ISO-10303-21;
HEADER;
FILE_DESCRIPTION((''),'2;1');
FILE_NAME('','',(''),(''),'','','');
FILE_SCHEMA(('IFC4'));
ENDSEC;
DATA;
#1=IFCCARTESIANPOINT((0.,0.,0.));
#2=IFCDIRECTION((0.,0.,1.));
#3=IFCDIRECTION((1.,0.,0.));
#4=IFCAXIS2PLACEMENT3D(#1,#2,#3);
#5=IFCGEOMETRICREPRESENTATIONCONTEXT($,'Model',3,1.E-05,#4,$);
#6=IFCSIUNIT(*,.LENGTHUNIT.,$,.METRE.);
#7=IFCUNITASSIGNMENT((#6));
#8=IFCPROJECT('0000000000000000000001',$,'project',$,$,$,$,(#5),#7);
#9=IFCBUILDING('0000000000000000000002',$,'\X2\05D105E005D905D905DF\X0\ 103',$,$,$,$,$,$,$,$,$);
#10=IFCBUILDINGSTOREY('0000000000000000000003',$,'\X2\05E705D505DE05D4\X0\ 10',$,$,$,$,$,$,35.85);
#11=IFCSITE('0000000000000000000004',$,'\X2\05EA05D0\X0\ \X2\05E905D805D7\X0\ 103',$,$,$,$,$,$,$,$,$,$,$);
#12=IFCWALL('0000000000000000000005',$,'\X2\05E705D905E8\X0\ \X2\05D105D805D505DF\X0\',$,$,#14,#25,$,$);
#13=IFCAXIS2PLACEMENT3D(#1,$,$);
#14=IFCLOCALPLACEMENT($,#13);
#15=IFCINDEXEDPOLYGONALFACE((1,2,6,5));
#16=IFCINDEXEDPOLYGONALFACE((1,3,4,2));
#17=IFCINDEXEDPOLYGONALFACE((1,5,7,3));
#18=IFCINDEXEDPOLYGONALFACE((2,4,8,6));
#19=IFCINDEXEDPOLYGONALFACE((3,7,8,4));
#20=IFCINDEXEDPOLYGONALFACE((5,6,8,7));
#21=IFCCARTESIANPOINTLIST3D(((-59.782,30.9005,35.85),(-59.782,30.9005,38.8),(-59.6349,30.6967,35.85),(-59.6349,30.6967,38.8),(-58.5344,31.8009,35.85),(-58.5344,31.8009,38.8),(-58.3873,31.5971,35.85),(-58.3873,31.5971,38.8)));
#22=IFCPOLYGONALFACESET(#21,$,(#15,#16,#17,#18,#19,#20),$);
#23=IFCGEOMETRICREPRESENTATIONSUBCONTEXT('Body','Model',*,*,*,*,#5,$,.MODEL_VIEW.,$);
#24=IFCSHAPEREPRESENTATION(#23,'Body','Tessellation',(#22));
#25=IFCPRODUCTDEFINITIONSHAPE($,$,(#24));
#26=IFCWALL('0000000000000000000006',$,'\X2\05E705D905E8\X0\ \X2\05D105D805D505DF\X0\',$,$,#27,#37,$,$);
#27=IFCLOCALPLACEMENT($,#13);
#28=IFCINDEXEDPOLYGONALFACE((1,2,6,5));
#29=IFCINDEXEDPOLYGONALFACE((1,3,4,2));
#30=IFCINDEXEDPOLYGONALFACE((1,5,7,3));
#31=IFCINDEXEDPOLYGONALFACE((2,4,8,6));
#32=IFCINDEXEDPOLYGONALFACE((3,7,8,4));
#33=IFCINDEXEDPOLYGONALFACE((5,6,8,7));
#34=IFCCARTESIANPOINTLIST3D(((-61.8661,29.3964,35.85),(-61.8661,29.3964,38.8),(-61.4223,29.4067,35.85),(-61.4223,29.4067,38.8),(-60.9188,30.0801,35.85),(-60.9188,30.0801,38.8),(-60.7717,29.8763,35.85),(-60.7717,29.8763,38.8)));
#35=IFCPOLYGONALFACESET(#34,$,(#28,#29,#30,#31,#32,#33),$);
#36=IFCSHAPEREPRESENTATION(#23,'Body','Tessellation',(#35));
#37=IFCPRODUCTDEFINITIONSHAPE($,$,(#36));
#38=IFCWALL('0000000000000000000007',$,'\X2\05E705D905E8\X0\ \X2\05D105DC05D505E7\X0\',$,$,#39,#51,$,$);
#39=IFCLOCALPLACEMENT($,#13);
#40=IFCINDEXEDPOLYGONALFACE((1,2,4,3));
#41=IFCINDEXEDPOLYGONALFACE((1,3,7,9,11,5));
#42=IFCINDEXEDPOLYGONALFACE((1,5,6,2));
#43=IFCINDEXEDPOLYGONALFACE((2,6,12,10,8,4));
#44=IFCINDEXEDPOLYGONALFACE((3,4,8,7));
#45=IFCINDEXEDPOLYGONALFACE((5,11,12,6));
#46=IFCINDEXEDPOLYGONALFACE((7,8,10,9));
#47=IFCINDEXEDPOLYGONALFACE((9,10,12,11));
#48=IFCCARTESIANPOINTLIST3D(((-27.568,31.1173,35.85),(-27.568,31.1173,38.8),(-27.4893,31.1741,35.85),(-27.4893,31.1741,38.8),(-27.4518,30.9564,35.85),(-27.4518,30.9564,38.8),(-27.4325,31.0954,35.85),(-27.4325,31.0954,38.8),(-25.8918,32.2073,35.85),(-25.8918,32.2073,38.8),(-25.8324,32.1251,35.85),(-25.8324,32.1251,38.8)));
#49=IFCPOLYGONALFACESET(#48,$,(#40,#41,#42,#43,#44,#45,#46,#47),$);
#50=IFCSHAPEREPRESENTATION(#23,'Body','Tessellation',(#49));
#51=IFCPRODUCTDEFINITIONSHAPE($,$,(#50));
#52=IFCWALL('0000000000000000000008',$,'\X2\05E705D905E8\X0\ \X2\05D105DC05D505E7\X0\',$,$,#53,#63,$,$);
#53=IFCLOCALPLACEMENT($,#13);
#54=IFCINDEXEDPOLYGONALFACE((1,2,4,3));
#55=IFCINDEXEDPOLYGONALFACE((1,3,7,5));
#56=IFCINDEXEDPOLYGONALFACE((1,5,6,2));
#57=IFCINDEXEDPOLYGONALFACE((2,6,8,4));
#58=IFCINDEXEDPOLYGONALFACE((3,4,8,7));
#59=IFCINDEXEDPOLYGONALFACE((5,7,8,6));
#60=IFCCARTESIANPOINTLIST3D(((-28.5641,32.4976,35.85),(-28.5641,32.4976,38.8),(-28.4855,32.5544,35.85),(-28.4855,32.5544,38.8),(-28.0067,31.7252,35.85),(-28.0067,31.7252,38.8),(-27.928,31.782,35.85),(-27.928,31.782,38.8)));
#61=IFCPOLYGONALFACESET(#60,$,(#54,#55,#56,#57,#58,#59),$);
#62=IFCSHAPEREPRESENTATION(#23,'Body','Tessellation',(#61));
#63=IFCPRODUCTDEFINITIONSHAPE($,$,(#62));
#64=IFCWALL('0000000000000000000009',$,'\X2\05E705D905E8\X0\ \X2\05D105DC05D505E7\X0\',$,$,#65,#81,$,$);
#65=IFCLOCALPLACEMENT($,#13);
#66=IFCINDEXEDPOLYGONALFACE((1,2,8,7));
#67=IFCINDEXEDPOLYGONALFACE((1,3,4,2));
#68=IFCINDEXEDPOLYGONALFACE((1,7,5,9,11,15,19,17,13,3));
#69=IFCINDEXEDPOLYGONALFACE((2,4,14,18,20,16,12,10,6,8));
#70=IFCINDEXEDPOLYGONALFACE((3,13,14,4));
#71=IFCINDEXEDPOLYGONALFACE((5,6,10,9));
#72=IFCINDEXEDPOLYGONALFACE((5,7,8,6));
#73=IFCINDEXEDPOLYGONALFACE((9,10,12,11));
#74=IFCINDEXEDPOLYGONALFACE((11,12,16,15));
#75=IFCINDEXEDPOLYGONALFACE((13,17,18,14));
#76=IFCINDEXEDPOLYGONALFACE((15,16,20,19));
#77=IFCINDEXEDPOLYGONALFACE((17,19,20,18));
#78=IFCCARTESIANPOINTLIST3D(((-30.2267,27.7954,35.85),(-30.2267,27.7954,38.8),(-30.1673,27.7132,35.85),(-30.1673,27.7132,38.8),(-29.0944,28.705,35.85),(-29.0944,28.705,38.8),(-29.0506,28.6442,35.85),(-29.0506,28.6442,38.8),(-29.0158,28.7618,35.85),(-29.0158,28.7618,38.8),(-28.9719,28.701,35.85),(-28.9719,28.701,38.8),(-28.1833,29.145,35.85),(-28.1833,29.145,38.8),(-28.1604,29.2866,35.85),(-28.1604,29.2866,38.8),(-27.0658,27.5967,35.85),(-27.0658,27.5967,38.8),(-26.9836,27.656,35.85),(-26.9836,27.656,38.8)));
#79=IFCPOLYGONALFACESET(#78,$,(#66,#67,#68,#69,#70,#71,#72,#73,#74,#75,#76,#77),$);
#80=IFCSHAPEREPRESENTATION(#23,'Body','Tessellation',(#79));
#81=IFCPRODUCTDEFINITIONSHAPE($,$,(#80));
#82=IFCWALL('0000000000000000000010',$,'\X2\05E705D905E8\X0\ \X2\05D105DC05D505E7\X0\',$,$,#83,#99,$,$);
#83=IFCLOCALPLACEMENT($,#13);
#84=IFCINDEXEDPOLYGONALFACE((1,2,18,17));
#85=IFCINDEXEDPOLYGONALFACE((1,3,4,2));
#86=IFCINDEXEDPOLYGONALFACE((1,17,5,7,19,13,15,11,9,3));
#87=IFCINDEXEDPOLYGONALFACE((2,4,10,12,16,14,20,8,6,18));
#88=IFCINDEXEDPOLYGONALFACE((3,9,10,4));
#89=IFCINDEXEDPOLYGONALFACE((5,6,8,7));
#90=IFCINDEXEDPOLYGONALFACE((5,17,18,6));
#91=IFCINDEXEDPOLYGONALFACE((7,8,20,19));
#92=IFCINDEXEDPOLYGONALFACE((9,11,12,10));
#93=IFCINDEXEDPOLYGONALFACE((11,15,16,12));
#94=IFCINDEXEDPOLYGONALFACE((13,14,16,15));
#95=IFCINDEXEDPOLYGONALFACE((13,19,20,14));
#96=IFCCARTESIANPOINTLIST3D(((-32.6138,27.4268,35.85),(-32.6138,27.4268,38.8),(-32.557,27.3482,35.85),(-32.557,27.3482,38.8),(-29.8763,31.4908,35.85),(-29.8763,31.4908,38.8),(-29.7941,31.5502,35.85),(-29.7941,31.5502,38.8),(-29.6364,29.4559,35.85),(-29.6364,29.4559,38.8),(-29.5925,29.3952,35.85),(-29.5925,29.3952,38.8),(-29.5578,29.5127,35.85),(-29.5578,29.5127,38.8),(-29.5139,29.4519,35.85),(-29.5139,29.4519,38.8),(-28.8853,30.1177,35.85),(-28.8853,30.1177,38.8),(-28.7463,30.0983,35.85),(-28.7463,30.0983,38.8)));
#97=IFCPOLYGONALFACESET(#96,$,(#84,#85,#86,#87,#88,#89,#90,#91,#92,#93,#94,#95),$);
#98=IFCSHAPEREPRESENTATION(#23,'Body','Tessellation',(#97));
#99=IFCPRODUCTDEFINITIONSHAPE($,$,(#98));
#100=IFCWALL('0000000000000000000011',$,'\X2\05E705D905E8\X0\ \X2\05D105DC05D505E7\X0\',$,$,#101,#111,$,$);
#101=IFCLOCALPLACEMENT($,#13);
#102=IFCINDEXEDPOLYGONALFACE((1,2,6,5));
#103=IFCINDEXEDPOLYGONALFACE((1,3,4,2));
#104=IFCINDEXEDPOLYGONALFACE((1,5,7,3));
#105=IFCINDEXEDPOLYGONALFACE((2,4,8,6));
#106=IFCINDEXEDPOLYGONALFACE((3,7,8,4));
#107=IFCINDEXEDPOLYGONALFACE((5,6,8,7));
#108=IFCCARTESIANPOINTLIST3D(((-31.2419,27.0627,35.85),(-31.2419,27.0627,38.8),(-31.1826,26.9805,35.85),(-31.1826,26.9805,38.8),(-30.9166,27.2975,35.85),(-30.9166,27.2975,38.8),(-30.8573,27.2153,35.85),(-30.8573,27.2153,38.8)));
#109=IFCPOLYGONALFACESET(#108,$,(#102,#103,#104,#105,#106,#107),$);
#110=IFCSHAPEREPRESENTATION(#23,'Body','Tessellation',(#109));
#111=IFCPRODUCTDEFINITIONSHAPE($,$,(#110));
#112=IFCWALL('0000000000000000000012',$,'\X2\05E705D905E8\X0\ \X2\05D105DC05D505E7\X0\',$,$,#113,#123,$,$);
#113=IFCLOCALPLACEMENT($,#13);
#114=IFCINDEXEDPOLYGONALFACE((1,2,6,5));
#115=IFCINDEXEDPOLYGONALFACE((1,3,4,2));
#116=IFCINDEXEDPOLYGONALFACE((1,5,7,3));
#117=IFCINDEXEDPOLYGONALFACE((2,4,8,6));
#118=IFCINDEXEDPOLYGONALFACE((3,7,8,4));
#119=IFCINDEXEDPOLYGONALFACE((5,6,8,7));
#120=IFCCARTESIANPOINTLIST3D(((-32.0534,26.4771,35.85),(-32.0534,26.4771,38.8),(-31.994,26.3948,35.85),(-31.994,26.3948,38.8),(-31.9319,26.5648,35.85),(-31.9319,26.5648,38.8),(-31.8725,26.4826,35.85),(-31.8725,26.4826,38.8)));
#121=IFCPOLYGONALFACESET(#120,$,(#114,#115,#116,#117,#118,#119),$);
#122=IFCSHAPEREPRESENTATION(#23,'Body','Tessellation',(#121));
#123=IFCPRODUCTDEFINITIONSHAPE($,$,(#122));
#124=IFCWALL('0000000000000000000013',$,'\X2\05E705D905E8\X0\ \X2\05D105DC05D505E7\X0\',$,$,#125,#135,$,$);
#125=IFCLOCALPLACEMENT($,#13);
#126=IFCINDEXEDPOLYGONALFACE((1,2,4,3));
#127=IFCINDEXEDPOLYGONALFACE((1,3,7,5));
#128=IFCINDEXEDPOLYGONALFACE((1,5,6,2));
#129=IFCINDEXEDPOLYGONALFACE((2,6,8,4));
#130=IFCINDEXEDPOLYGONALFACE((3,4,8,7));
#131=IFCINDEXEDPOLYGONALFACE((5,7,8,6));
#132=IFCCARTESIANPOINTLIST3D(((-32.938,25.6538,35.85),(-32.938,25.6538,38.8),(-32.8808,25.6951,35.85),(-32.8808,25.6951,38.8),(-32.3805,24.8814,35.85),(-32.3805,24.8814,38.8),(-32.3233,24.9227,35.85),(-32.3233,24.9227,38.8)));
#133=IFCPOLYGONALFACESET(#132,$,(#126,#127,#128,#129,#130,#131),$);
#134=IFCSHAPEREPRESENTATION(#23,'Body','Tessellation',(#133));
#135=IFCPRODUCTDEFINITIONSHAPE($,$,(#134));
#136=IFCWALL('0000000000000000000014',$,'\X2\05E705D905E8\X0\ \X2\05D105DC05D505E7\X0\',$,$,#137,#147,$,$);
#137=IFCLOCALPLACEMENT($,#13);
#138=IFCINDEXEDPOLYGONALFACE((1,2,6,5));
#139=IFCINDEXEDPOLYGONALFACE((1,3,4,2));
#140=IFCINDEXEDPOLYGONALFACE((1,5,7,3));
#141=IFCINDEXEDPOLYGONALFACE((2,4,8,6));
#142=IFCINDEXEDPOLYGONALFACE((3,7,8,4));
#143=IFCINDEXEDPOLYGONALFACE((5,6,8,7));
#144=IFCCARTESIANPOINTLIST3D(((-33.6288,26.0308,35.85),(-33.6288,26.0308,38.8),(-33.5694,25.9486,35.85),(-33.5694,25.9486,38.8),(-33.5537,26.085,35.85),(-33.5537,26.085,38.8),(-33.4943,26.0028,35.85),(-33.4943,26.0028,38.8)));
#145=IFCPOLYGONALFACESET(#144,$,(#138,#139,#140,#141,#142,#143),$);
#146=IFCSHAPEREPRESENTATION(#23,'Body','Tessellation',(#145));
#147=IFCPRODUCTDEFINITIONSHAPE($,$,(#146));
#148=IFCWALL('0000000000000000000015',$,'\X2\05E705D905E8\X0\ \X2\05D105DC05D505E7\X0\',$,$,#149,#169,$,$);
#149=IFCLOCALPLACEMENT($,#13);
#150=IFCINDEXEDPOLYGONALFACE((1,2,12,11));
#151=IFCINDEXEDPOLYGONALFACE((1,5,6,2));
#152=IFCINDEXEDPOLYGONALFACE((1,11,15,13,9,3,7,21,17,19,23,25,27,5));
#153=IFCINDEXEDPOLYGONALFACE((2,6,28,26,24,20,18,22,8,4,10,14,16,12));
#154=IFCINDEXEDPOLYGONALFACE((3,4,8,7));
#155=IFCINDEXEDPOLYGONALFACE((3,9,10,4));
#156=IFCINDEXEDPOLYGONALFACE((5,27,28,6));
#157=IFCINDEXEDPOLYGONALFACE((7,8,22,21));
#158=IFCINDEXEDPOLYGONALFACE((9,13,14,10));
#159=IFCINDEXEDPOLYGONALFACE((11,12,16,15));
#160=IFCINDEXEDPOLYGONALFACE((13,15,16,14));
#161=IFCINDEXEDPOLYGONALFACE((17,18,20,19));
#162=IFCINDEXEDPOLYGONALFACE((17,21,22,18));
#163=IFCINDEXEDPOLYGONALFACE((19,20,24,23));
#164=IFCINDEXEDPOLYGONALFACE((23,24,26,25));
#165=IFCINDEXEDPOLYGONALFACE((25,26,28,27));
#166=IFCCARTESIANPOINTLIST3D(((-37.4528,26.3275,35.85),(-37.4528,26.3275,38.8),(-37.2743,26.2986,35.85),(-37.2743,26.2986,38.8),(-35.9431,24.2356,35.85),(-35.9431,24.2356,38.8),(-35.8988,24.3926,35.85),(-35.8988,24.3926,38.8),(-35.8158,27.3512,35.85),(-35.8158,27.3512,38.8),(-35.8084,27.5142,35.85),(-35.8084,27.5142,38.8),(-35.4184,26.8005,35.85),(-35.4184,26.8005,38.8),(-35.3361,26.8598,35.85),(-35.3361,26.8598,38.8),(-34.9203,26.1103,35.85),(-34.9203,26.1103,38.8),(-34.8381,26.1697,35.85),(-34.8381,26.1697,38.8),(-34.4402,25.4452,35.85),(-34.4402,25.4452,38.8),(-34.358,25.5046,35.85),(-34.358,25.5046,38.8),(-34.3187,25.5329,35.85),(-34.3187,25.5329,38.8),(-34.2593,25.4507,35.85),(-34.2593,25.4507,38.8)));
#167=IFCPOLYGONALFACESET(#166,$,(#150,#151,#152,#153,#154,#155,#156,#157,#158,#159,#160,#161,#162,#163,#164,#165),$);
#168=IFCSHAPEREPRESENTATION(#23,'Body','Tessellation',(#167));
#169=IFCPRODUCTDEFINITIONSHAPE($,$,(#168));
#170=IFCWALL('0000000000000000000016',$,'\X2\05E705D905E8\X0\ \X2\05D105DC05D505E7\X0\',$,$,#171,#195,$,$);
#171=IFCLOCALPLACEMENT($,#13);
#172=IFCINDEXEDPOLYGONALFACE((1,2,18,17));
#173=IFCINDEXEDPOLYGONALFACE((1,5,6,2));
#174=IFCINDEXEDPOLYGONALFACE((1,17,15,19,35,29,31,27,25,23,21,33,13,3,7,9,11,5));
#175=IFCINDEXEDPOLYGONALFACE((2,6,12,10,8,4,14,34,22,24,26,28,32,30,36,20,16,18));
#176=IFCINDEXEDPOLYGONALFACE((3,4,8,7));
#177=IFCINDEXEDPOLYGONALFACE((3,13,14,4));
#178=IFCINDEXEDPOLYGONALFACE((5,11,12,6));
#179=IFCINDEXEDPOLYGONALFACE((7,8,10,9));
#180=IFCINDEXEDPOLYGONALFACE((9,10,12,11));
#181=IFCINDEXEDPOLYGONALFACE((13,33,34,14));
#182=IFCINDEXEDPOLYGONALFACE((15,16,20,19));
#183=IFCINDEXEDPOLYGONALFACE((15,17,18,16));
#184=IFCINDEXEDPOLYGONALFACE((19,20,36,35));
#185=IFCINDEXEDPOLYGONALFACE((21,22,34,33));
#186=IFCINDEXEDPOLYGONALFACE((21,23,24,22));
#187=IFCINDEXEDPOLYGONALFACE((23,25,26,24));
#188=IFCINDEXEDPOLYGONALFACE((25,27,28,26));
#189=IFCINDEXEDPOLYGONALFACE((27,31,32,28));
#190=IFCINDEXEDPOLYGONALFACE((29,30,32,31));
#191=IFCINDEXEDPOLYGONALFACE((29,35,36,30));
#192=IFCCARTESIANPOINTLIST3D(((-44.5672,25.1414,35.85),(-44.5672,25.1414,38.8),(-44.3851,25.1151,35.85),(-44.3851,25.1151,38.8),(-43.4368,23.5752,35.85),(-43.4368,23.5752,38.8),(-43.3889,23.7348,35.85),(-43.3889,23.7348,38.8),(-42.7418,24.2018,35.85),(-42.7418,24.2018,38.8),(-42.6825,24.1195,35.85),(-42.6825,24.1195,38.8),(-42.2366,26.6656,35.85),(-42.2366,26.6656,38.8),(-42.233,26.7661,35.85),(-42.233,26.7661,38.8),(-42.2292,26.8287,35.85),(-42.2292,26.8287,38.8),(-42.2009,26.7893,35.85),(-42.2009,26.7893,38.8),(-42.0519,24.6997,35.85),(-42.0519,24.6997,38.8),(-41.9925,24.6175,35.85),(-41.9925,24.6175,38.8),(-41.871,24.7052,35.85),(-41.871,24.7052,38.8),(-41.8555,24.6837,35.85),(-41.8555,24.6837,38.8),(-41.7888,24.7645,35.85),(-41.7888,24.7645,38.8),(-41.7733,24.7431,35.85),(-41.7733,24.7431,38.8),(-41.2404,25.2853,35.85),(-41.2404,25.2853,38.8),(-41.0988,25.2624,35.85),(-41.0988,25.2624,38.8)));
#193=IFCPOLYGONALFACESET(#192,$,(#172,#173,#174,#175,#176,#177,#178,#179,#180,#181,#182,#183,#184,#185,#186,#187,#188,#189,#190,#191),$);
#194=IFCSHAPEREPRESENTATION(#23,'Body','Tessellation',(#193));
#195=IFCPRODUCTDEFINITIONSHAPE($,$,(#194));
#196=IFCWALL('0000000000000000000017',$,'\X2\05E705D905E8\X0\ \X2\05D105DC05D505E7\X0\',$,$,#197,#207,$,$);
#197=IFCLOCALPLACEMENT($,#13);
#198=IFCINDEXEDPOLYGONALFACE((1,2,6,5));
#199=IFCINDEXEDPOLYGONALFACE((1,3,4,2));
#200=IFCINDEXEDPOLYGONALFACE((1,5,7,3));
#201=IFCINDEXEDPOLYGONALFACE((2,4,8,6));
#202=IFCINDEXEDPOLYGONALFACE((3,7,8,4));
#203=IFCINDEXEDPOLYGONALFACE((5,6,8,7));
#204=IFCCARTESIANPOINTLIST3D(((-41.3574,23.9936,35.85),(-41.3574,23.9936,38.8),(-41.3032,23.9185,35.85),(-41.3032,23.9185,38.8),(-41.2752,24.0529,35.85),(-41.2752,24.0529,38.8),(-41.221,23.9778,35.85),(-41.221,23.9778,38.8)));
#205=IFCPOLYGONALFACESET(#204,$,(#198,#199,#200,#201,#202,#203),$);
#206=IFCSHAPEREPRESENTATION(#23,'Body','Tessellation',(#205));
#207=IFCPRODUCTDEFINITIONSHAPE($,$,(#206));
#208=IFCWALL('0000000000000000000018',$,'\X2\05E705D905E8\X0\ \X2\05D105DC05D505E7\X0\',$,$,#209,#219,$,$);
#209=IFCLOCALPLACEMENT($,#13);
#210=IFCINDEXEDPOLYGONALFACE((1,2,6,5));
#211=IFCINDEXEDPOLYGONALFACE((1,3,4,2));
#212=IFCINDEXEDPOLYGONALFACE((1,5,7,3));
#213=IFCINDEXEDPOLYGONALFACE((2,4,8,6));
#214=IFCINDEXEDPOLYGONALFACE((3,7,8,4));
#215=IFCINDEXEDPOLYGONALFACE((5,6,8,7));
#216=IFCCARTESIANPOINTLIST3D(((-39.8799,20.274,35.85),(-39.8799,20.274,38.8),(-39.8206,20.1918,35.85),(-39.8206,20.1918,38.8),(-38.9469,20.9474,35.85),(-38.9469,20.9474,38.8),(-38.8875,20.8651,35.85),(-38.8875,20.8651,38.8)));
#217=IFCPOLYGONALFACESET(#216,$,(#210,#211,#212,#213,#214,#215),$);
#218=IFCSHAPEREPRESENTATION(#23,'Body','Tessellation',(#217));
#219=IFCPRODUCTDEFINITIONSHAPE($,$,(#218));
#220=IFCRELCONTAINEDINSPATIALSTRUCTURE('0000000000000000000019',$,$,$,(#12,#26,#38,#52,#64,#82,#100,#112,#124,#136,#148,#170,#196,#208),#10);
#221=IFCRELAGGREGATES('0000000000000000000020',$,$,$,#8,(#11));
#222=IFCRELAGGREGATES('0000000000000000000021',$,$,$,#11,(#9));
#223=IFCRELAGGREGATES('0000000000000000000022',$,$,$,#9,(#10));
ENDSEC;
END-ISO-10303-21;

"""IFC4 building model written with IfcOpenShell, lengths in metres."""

from ifc_helpers import new_model, si_unit, frame, origin_with_axes, context, subcontext, project, spatial, polyline, outline, extrude, element, save


model = new_model("IFC4")

# Units and contexts
model_context = context("Model", 3, precision=1e-05, world=origin_with_axes())
body_context = subcontext(model_context, "Body", "Model", "MODEL_VIEW")
ifc_project = project(units=[si_unit("LENGTHUNIT", "METRE")], contexts=[model_context])

# Site, building, storey
site = spatial("IfcSite", under=ifc_project, Name="תא שטח 103")
building = spatial("IfcBuilding", under=site, Name="בניין 103")
storey = spatial("IfcBuildingStorey", under=building, Name="קומה 10", Elevation=35.85)

# Walls
element("IfcWall", 1, inside=storey, Name="קיר בטון", context=body_context, shape_type="SweptSolid", body=[
    extrude(outline(polyline([(-59.6349, 30.6967), (-59.782, 30.9005), (-58.5344, 31.8009), (-58.3873, 31.5971), (-59.6349, 30.6967)])), frame((0.0, 0.0, 35.85)), (0.0, 0.0, 1.0), 2.95),
])
element("IfcWall", 2, inside=storey, Name="קיר בטון", context=body_context, shape_type="SweptSolid", body=[
    extrude(outline(polyline([(-61.4223, 29.4067), (-61.8661, 29.3964), (-60.9188, 30.0801), (-60.7717, 29.8763), (-61.4223, 29.4067)])), frame((0.0, 0.0, 35.85)), (0.0, 0.0, 1.0), 2.95),
])
element("IfcWall", 3, inside=storey, Name="קיר בלוק", context=body_context, shape_type="SweptSolid", body=[
    extrude(outline(polyline([(-27.4893, 31.1741), (-27.4325, 31.0954), (-25.8918, 32.2073), (-25.8324, 32.1251), (-27.4518, 30.9564), (-27.568, 31.1173), (-27.4893, 31.1741)])), frame((0.0, 0.0, 35.85)), (0.0, 0.0, 1.0), 2.95),
])
element("IfcWall", 4, inside=storey, Name="קיר בלוק", context=body_context, shape_type="SweptSolid", body=[
    extrude(outline(polyline([(-28.4855, 32.5544), (-27.928, 31.782), (-28.0067, 31.7252), (-28.5641, 32.4976), (-28.4855, 32.5544)])), frame((0.0, 0.0, 35.85)), (0.0, 0.0, 1.0), 2.95),
])
element("IfcWall", 5, inside=storey, Name="קיר בלוק", context=body_context, shape_type="SweptSolid", body=[
    extrude(outline(polyline([(-30.1673, 27.7132), (-30.2267, 27.7954), (-29.0506, 28.6442), (-29.0944, 28.705), (-29.0158, 28.7618), (-28.9719, 28.701), (-28.1604, 29.2866), (-26.9836, 27.656), (-27.0658, 27.5967), (-28.1833, 29.145), (-30.1673, 27.7132)])), frame((0.0, 0.0, 35.85)), (0.0, 0.0, 1.0), 2.95),
])
element("IfcWall", 6, inside=storey, Name="קיר בלוק", context=body_context, shape_type="SweptSolid", body=[
    extrude(outline(polyline([(-29.5925, 29.3952), (-29.6364, 29.4559), (-32.557, 27.3482), (-32.6138, 27.4268), (-28.8853, 30.1177), (-29.8763, 31.4908), (-29.7941, 31.5502), (-28.7463, 30.0983), (-29.5578, 29.5127), (-29.5139, 29.4519), (-29.5925, 29.3952)])), frame((0.0, 0.0, 35.85)), (0.0, 0.0, 1.0), 2.95),
])
element("IfcWall", 7, inside=storey, Name="קיר בלוק", context=body_context, shape_type="SweptSolid", body=[
    extrude(outline(polyline([(-30.9166, 27.2975), (-30.8573, 27.2153), (-31.1826, 26.9805), (-31.2419, 27.0627), (-30.9166, 27.2975)])), frame((0.0, 0.0, 35.85)), (0.0, 0.0, 1.0), 2.95),
])
element("IfcWall", 8, inside=storey, Name="קיר בלוק", context=body_context, shape_type="SweptSolid", body=[
    extrude(outline(polyline([(-31.8725, 26.4826), (-31.994, 26.3948), (-32.0534, 26.4771), (-31.9319, 26.5648), (-31.8725, 26.4826)])), frame((0.0, 0.0, 35.85)), (0.0, 0.0, 1.0), 2.95),
])
element("IfcWall", 9, inside=storey, Name="קיר בלוק", context=body_context, shape_type="SweptSolid", body=[
    extrude(outline(polyline([(-32.3233, 24.9227), (-32.3805, 24.8814), (-32.938, 25.6538), (-32.8808, 25.6951), (-32.3233, 24.9227)])), frame((0.0, 0.0, 35.85)), (0.0, 0.0, 1.0), 2.95),
])
element("IfcWall", 10, inside=storey, Name="קיר בלוק", context=body_context, shape_type="SweptSolid", body=[
    extrude(outline(polyline([(-33.5537, 26.085), (-33.4943, 26.0028), (-33.5694, 25.9486), (-33.6288, 26.0308), (-33.5537, 26.085)])), frame((0.0, 0.0, 35.85)), (0.0, 0.0, 1.0), 2.95),
])
element("IfcWall", 11, inside=storey, Name="קיר בלוק", context=body_context, shape_type="SweptSolid", body=[
    extrude(outline(polyline([(-35.8988, 24.3926), (-34.4402, 25.4452), (-34.9203, 26.1103), (-34.8381, 26.1697), (-34.358, 25.5046), (-34.3187, 25.5329), (-34.2593, 25.4507), (-35.9431, 24.2356), (-37.4528, 26.3275), (-35.8084, 27.5142), (-35.3361, 26.8598), (-35.4184, 26.8005), (-35.8158, 27.3512), (-37.2743, 26.2986), (-35.8988, 24.3926)])), frame((0.0, 0.0, 35.85)), (0.0, 0.0, 1.0), 2.95),
])
element("IfcWall", 12, inside=storey, Name="קיר בלוק", context=body_context, shape_type="SweptSolid", body=[
    extrude(outline(polyline([(-41.8555, 24.6837), (-41.871, 24.7052), (-41.9925, 24.6175), (-42.0519, 24.6997), (-41.2404, 25.2853), (-42.2366, 26.6656), (-44.3851, 25.1151), (-43.3889, 23.7348), (-42.7418, 24.2018), (-42.6825, 24.1195), (-43.4368, 23.5752), (-44.5672, 25.1414), (-42.2292, 26.8287), (-42.233, 26.7661), (-42.2009, 26.7893), (-41.0988, 25.2624), (-41.7888, 24.7645), (-41.7733, 24.7431), (-41.8555, 24.6837)])), frame((0.0, 0.0, 35.85)), (0.0, 0.0, 1.0), 2.95),
])
element("IfcWall", 13, inside=storey, Name="קיר בלוק", context=body_context, shape_type="SweptSolid", body=[
    extrude(outline(polyline([(-41.221, 23.9778), (-41.3032, 23.9185), (-41.3574, 23.9936), (-41.2752, 24.0529), (-41.221, 23.9778)])), frame((0.0, 0.0, 35.85)), (0.0, 0.0, 1.0), 2.95),
])
element("IfcWall", 14, inside=storey, Name="קיר בלוק", context=body_context, shape_type="SweptSolid", body=[
    extrude(outline(polyline([(-39.8206, 20.1918), (-39.8799, 20.274), (-38.9469, 20.9474), (-38.8875, 20.8651), (-39.8206, 20.1918)])), frame((0.0, 0.0, 35.85)), (0.0, 0.0, 1.0), 2.95),
])

save(model, "model.ifc")
